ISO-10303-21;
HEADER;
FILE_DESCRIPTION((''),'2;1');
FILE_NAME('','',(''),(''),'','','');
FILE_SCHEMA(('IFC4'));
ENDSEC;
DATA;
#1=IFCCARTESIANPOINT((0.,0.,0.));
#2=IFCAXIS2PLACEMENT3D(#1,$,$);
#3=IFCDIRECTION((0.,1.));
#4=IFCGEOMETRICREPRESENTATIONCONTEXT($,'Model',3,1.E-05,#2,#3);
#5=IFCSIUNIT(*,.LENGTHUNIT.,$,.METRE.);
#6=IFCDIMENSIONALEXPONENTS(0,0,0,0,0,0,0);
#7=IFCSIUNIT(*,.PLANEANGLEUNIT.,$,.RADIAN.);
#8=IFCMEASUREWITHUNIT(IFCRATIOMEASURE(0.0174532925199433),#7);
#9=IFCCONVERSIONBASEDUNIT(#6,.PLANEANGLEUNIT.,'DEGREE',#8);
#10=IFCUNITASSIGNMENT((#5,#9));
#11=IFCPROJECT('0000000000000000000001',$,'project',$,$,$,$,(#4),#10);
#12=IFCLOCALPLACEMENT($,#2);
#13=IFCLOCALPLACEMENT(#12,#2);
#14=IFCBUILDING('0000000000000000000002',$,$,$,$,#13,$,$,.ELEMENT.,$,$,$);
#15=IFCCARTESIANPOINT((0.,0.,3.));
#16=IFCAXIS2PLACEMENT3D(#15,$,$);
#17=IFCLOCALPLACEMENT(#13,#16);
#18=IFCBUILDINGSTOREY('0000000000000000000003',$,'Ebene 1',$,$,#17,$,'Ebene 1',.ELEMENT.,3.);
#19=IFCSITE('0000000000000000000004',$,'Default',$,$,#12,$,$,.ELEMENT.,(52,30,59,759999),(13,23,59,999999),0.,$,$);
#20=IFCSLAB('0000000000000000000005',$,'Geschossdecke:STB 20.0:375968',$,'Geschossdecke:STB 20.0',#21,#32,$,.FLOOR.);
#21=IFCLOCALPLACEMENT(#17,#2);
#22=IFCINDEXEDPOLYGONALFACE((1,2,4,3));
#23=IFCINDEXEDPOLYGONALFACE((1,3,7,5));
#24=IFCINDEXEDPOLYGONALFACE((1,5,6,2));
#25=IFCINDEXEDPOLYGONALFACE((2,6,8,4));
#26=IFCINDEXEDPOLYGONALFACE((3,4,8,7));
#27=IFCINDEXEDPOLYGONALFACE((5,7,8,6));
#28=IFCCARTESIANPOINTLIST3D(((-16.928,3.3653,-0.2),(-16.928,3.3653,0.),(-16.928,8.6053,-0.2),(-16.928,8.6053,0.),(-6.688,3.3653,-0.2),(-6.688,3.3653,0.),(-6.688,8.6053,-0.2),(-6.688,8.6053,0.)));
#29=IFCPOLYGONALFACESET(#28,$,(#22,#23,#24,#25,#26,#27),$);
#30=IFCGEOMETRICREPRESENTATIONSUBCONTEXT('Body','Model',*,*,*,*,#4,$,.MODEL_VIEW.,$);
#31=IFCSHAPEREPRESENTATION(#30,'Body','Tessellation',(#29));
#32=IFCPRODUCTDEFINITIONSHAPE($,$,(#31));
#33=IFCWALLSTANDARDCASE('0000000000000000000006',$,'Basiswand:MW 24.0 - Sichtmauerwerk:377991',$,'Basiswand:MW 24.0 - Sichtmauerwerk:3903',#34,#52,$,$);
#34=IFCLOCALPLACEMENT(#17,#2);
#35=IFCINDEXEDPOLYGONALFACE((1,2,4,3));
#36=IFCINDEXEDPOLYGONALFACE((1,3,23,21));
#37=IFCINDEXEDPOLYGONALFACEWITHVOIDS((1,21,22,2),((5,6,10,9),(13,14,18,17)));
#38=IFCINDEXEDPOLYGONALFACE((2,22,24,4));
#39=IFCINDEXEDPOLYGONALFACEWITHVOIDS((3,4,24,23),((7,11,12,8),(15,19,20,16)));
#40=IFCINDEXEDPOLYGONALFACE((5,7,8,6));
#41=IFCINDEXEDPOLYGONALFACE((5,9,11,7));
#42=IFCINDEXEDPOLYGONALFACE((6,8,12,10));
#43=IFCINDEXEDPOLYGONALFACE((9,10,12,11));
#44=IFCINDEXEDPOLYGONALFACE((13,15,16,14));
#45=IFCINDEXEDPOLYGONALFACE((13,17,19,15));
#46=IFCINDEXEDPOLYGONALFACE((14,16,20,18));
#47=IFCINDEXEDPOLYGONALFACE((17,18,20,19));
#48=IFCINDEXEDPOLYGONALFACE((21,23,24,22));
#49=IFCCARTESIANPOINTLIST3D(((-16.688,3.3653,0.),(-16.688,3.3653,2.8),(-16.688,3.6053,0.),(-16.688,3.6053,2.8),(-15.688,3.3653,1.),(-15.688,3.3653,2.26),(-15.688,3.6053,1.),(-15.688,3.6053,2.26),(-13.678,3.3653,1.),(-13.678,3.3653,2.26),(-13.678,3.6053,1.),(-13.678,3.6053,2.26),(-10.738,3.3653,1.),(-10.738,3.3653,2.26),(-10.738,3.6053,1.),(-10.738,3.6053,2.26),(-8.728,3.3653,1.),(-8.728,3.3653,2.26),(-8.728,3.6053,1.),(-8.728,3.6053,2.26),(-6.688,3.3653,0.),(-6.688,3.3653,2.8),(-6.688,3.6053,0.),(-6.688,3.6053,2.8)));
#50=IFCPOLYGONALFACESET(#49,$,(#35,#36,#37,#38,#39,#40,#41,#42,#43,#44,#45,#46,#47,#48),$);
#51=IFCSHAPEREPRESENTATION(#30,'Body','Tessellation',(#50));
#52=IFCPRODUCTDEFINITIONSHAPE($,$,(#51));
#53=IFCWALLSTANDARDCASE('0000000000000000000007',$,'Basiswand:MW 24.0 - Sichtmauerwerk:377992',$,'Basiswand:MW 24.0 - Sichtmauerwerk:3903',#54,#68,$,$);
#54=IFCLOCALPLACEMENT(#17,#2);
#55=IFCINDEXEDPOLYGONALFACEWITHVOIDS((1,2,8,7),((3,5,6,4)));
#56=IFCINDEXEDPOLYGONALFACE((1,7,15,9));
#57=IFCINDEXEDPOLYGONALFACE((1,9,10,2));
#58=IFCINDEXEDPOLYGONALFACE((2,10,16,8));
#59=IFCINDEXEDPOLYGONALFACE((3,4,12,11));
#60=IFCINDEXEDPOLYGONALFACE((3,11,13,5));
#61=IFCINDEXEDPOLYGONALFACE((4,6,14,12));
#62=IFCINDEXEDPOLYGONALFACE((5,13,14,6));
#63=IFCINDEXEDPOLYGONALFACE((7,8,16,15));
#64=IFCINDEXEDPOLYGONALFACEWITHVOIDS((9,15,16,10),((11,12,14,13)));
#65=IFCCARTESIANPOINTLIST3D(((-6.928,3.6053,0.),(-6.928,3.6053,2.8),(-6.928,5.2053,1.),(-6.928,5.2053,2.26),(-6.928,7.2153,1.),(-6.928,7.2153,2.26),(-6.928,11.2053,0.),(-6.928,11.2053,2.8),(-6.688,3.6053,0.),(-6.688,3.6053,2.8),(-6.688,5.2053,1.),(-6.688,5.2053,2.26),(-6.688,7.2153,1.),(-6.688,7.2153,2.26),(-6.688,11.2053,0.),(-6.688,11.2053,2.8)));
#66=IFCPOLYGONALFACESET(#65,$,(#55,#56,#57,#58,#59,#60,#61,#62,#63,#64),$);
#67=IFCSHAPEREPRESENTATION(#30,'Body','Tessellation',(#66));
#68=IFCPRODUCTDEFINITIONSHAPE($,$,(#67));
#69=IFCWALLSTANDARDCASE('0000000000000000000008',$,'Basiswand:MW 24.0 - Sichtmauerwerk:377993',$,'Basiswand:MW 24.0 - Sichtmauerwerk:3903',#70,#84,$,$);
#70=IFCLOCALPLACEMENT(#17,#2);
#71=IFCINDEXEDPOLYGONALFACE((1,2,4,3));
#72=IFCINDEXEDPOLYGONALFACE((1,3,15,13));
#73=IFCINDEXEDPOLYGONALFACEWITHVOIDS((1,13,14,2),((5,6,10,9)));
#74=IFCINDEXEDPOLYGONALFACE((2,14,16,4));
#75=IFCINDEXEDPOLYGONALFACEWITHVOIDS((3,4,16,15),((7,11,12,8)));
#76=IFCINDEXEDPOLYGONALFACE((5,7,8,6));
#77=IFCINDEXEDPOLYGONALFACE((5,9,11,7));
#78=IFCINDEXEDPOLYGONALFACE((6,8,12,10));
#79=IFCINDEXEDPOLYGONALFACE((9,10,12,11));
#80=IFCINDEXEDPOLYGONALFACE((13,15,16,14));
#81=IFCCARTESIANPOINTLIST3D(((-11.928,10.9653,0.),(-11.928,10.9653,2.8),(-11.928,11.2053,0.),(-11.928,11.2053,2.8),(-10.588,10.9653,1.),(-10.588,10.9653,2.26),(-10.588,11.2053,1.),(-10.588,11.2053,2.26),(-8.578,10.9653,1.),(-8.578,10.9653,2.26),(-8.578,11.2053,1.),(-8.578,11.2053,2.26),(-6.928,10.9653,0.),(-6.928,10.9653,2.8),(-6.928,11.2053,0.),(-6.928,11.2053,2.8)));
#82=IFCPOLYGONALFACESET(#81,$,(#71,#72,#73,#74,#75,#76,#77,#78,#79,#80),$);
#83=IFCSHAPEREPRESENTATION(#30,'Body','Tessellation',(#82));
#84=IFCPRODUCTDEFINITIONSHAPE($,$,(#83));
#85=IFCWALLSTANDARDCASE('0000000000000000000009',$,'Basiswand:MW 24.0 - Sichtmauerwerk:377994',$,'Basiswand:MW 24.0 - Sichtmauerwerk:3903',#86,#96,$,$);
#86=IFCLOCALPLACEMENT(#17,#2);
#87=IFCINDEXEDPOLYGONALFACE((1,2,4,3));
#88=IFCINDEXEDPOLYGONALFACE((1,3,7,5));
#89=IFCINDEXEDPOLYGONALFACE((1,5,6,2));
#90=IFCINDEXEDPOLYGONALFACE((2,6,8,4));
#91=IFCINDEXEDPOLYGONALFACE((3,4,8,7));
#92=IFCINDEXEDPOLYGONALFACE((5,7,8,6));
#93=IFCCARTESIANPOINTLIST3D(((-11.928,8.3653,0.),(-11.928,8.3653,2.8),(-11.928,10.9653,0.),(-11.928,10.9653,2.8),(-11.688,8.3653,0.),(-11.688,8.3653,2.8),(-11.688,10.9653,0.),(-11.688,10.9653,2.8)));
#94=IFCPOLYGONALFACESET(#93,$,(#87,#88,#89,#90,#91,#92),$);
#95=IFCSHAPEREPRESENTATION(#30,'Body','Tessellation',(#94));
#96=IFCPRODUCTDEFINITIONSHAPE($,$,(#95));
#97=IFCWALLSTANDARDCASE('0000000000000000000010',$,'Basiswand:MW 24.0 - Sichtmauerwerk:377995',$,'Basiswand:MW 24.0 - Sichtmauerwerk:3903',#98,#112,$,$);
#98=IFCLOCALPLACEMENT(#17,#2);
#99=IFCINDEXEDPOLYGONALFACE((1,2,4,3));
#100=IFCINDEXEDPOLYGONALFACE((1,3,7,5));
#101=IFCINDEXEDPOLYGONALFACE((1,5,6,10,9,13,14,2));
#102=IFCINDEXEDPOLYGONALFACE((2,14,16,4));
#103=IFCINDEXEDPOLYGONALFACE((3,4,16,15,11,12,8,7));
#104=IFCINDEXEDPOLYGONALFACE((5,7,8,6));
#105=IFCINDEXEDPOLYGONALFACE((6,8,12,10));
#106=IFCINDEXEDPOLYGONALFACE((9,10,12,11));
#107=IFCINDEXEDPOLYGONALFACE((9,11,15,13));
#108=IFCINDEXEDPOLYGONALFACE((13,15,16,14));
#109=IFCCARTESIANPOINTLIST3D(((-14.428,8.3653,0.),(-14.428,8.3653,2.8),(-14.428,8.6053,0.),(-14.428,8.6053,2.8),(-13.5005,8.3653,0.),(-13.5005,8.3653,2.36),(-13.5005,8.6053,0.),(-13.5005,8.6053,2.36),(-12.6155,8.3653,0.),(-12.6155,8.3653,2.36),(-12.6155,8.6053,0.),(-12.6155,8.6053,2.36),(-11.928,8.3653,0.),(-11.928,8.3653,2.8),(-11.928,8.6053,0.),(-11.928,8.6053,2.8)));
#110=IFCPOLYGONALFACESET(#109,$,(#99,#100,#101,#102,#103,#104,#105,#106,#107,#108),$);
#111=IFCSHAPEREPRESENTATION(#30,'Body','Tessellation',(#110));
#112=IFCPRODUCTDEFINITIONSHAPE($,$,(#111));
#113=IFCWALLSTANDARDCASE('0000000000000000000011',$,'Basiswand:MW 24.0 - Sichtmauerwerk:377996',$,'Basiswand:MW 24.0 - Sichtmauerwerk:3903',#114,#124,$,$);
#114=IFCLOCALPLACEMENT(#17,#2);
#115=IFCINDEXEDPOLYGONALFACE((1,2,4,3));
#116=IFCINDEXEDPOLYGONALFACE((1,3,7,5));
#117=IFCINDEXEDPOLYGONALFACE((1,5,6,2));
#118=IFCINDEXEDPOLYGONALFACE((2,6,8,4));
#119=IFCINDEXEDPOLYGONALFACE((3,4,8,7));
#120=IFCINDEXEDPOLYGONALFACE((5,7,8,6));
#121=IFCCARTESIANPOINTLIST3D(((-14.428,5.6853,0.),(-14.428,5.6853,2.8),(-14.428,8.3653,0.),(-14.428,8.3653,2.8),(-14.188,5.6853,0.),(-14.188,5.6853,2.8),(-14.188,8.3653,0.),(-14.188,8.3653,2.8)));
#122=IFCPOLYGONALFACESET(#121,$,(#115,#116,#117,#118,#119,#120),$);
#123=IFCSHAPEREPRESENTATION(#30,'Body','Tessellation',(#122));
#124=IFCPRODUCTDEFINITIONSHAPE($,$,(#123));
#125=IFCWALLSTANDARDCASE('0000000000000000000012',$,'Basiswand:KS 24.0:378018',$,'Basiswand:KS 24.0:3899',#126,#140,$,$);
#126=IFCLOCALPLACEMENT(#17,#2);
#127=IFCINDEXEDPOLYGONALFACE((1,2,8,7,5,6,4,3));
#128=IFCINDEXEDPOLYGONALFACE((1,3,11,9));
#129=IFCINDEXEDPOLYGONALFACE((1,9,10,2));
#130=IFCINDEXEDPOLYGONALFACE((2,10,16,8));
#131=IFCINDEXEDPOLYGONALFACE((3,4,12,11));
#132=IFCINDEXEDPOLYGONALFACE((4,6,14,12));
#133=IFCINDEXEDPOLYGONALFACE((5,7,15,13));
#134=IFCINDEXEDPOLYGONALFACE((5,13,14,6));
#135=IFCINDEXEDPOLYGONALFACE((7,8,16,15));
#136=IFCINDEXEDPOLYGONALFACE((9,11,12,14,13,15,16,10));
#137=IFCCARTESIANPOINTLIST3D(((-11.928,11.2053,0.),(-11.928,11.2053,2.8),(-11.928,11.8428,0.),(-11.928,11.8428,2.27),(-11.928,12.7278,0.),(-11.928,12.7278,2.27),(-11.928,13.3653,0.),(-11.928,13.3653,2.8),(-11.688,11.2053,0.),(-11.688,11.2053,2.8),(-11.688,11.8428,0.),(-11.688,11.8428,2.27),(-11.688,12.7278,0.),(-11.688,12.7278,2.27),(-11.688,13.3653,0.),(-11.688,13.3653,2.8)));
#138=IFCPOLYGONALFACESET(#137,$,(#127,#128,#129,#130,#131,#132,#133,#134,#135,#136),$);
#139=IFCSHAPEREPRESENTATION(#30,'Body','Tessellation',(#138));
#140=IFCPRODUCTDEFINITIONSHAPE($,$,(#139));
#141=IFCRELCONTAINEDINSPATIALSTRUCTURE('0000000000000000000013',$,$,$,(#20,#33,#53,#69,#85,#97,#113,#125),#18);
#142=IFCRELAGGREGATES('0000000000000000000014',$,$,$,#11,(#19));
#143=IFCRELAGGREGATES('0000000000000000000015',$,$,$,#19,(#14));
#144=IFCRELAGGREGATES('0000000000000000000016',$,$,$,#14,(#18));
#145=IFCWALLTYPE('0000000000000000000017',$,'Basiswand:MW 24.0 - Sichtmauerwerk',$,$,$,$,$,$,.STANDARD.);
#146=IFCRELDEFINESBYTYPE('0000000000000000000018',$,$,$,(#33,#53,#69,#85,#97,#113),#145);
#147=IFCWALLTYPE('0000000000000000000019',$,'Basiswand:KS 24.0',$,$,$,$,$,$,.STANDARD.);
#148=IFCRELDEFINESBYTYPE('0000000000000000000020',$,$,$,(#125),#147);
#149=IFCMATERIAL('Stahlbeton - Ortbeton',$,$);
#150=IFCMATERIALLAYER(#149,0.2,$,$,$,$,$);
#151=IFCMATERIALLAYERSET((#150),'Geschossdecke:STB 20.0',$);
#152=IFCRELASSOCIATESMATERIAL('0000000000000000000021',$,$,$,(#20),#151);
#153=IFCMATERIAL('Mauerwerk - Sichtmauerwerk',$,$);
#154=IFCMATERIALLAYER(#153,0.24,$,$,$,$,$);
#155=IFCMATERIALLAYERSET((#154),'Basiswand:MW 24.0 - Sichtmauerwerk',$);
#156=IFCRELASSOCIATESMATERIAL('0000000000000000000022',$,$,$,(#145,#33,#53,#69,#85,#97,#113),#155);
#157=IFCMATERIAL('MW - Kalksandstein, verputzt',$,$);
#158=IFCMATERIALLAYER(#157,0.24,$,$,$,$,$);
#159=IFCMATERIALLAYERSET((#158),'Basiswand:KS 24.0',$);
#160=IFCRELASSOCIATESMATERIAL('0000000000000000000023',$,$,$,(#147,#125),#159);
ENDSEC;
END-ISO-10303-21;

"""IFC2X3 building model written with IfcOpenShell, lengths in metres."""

from ifc_helpers import new_model, entity, si_unit, converted_unit, direction, frame, frame_2d, origin, origin_2d_with_axis, place, context, subcontext, project, spatial, polyline, rectangle, extrude, clip, bounded_halfspace, material, layer, layer_set, layer_usage, type_object, element, save


model = new_model("IFC2X3")

# Units and contexts
model_context = context("Model", 3, precision=1e-05, world=origin(), true_north=direction((0.0, 1.0)))
body_context = subcontext(model_context, "Body", "Model", "MODEL_VIEW")
ifc_project = project(units=[si_unit("LENGTHUNIT", "METRE"), converted_unit("PLANEANGLEUNIT", "DEGREE", entity("IfcRatioMeasure", 0.0174532925199433), si_unit("PLANEANGLEUNIT", "RADIAN"), dimensions=[0, 0, 0, 0, 0, 0, 0])], contexts=[model_context])

# Site, building, storey
site_placement = place(None, origin())
site = spatial("IfcSite", under=ifc_project, at=site_placement, Name="Default", CompositionType="ELEMENT", RefLatitude=(52, 30, 59, 759999), RefLongitude=(13, 23, 59, 999999), RefElevation=0.0)
building_placement = place(site_placement, origin())
building = spatial("IfcBuilding", under=site, at=building_placement, CompositionType="ELEMENT")
storey_placement = place(building_placement, frame((0.0, 0.0, 3.0)))
storey = spatial("IfcBuildingStorey", under=building, at=storey_placement, Name="Ebene 1", LongName="Ebene 1", CompositionType="ELEMENT", Elevation=3.0)

# Shared definitions
ifc_material_1 = material(Name="Stahlbeton - Ortbeton")

# Slab
ifc_layer_1 = layer(ifc_material_1, 0.2)
ifc_layer_set_1 = layer_set([ifc_layer_1], Name="Geschossdecke:STB 20.0")
ifc_layer_usage_1 = layer_usage(ifc_layer_set_1, "AXIS3", "POSITIVE", 0.0)
slab_1_placement = place(storey_placement, origin())
element("IfcSlab", 1, at=slab_1_placement, inside=storey, material=ifc_layer_usage_1, Name="Geschossdecke:STB 20.0:375968", ObjectType="Geschossdecke:STB 20.0", PredefinedType="FLOOR", context=body_context, shape_type="SweptSolid", body=[
    extrude(rectangle(XDim=5.24, YDim=10.24, at=origin_2d_with_axis()), frame((-11.808, 5.9853, 0.0), z_axis=(0.0, 0.0, -1.0), x_axis=(0.0, 1.0, 0.0)), (0.0, 0.0, 1.0), 0.2),
])

# Wall, openings
ifc_material_2 = material(Name="Mauerwerk - Sichtmauerwerk")
ifc_layer_2 = layer(ifc_material_2, 0.24)
ifc_layer_set_2 = layer_set([ifc_layer_2], Name="Basiswand:MW 24.0 - Sichtmauerwerk")
ifc_layer_usage_2 = layer_usage(ifc_layer_set_2, "AXIS2", "NEGATIVE", 0.12)
wall_type_1 = type_object("IfcWallType", Name="Basiswand:MW 24.0 - Sichtmauerwerk", PredefinedType="STANDARD", material=ifc_layer_set_2)
wall_1_placement = place(storey_placement, frame((-16.688, 3.4853, 0.0)))
wall_1 = element("IfcWallStandardCase", 2, at=wall_1_placement, inside=storey, type_object=wall_type_1, material=ifc_layer_usage_2, Name="Basiswand:MW 24.0 - Sichtmauerwerk:377991", ObjectType="Basiswand:MW 24.0 - Sichtmauerwerk:3903", context=body_context, shape_type="Clipping", body=[
    clip(extrude(rectangle(XDim=10.0, YDim=0.24, at=frame_2d((5.0, 0.0), x_axis=(-1.0, 0.0))), origin(), (0.0, 0.0, 1.0), 2.8), bounded_halfspace(frame((0.0, -0.12, 2.8), z_axis=(0.0, 0.0, -1.0), x_axis=(-1.0, 0.0, 0.0)), True, frame((0.0, -0.12, 2.8)), polyline([(0.0, 0.0), (10.0, 0.0), (10.0, 0.24), (9.76, 0.24), (0.0, 0.24), (0.0, 0.0)]))),
])
opening_1_placement = place(wall_1_placement, frame((1.0, -0.12, 1.0)))
element("IfcOpeningElement", 3, at=opening_1_placement, cuts=wall_1, ObjectType="Opening", context=body_context, shape_type="SweptSolid", body=[
    extrude(rectangle(XDim=1.26, YDim=2.01, at=frame_2d((0.63, 1.005), x_axis=(1.0, 0.0))), frame((0.0, 0.0, 0.0), z_axis=(0.0, 1.0, 0.0), x_axis=(0.0, 0.0, 1.0)), (0.0, 0.0, 1.0), 0.24),
])
opening_2_placement = place(wall_1_placement, frame((5.95, -0.12, 1.0)))
element("IfcOpeningElement", 4, at=opening_2_placement, cuts=wall_1, ObjectType="Opening", context=body_context, shape_type="SweptSolid", body=[
    extrude(rectangle(XDim=1.26, YDim=2.01, at=frame_2d((0.63, 1.005), x_axis=(1.0, 0.0))), frame((0.0, 0.0, 0.0), z_axis=(0.0, 1.0, 0.0), x_axis=(0.0, 0.0, 1.0)), (0.0, 0.0, 1.0), 0.24),
])

# Walls, openings
ifc_layer_usage_3 = layer_usage(ifc_layer_set_2, "AXIS2", "NEGATIVE", 0.12)
wall_2_placement = place(storey_placement, frame((-6.808, 3.6053, 0.0), z_axis=(0.0, 0.0, 1.0), x_axis=(0.0, 1.0, 0.0)))
wall_2 = element("IfcWallStandardCase", 5, at=wall_2_placement, inside=storey, type_object=wall_type_1, material=ifc_layer_usage_3, Name="Basiswand:MW 24.0 - Sichtmauerwerk:377992", ObjectType="Basiswand:MW 24.0 - Sichtmauerwerk:3903", context=body_context, shape_type="Clipping", body=[
    clip(clip(extrude(rectangle(XDim=7.6, YDim=0.24, at=frame_2d((3.8, 0.0), x_axis=(-1.0, 0.0))), origin(), (0.0, 0.0, 1.0), 2.8), bounded_halfspace(frame((0.0, -0.12, 2.8), z_axis=(0.0, 0.0, -1.0), x_axis=(0.0, 1.0, 0.0)), True, frame((0.0, -0.12, 2.8)), polyline([(0.0, 0.0), (5.0, 0.0), (5.0, 0.24), (0.0, 0.24), (0.0, 0.0)]))), bounded_halfspace(frame((5.005, -0.12, 2.8), z_axis=(0.0, 0.0, -1.0), x_axis=(1.0, 0.0, 0.0)), True, frame((5.005, -0.12, 2.8)), polyline([(0.0, 0.0), (2.595, 0.0), (2.595, 0.24), (2.355, 0.24), (0.0, 0.24), (0.0, 0.0)]))),
])
opening_3_placement = place(wall_2_placement, frame((1.6, -0.12, 1.0)))
element("IfcOpeningElement", 6, at=opening_3_placement, cuts=wall_2, ObjectType="Opening", context=body_context, shape_type="SweptSolid", body=[
    extrude(rectangle(XDim=1.26, YDim=2.01, at=frame_2d((0.63, 1.005), x_axis=(1.0, 0.0))), frame((0.0, 0.0, 0.0), z_axis=(0.0, 1.0, 0.0), x_axis=(0.0, 0.0, 1.0)), (0.0, 0.0, 1.0), 0.24),
])
ifc_layer_usage_4 = layer_usage(ifc_layer_set_2, "AXIS2", "NEGATIVE", 0.12)
wall_3_placement = place(storey_placement, frame((-6.928, 11.0853, 0.0), z_axis=(0.0, 0.0, 1.0), x_axis=(-1.0, 0.0, 0.0)))
wall_3 = element("IfcWallStandardCase", 7, at=wall_3_placement, inside=storey, type_object=wall_type_1, material=ifc_layer_usage_4, Name="Basiswand:MW 24.0 - Sichtmauerwerk:377993", ObjectType="Basiswand:MW 24.0 - Sichtmauerwerk:3903", context=body_context, shape_type="Clipping", body=[
    clip(extrude(rectangle(XDim=5.0, YDim=0.24, at=frame_2d((2.5, 0.0), x_axis=(-1.0, 0.0))), origin(), (0.0, 0.0, 1.0), 2.8), bounded_halfspace(frame((0.0, -0.12, 2.8), z_axis=(0.0, 0.0, -1.0), x_axis=(0.0, -1.0, 0.0)), True, frame((0.0, -0.12, 2.8)), polyline([(0.0, 0.0), (4.76, 0.0), (5.0, 0.0), (5.0, 0.24), (4.76, 0.24), (0.0, 0.24), (0.0, 0.0)]))),
])
opening_4_placement = place(wall_3_placement, frame((1.65, -0.12, 1.0)))
element("IfcOpeningElement", 8, at=opening_4_placement, cuts=wall_3, ObjectType="Opening", context=body_context, shape_type="SweptSolid", body=[
    extrude(rectangle(XDim=1.26, YDim=2.01, at=frame_2d((0.63, 1.005), x_axis=(1.0, 0.0))), frame((0.0, 0.0, 0.0), z_axis=(0.0, 1.0, 0.0), x_axis=(0.0, 0.0, 1.0)), (0.0, 0.0, 1.0), 0.24),
])

# Wall
ifc_layer_usage_5 = layer_usage(ifc_layer_set_2, "AXIS2", "NEGATIVE", 0.12)
wall_4_placement = place(storey_placement, frame((-11.808, 10.9653, 0.0), z_axis=(0.0, 0.0, 1.0), x_axis=(0.0, -1.0, 0.0)))
element("IfcWallStandardCase", 9, at=wall_4_placement, inside=storey, type_object=wall_type_1, material=ifc_layer_usage_5, Name="Basiswand:MW 24.0 - Sichtmauerwerk:377994", ObjectType="Basiswand:MW 24.0 - Sichtmauerwerk:3903", context=body_context, shape_type="Clipping", body=[
    clip(clip(extrude(rectangle(XDim=2.6, YDim=0.24, at=frame_2d((1.3, 0.0), x_axis=(-1.0, 0.0))), origin(), (0.0, 0.0, 1.0), 2.8), bounded_halfspace(frame((2.36, -0.12, 2.8), z_axis=(0.0, 0.0, -1.0), x_axis=(0.0, -1.0, 0.0)), True, frame((2.36, -0.12, 2.8)), polyline([(0.0, 0.0), (0.24, 0.0), (0.24, 0.24), (0.0, 0.24), (0.0, 0.0)]))), bounded_halfspace(frame((0.0, -0.12, 2.8), z_axis=(0.0, 0.0, -1.0), x_axis=(-1.0, 0.0, 0.0)), True, frame((0.0, -0.12, 2.8)), polyline([(0.0, 0.0), (2.355, 0.0), (2.355, 0.24), (0.0, 0.24), (0.0, 0.0)]))),
])

# Wall, opening
ifc_layer_usage_6 = layer_usage(ifc_layer_set_2, "AXIS2", "NEGATIVE", 0.12)
wall_5_placement = place(storey_placement, frame((-11.928, 8.4853, 0.0), z_axis=(0.0, 0.0, 1.0), x_axis=(-1.0, 0.0, 0.0)))
wall_5 = element("IfcWallStandardCase", 10, at=wall_5_placement, inside=storey, type_object=wall_type_1, material=ifc_layer_usage_6, Name="Basiswand:MW 24.0 - Sichtmauerwerk:377995", ObjectType="Basiswand:MW 24.0 - Sichtmauerwerk:3903", context=body_context, shape_type="Clipping", body=[
    clip(extrude(rectangle(XDim=2.5, YDim=0.24, at=frame_2d((1.25, 0.0), x_axis=(-1.0, 0.0))), origin(), (0.0, 0.0, 1.0), 2.8), bounded_halfspace(frame((0.0, -0.12, 2.8), z_axis=(0.0, 0.0, -1.0), x_axis=(1.0, 0.0, 0.0)), True, frame((0.0, -0.12, 2.8)), polyline([(0.0, 0.0), (2.5, 0.0), (2.5, 0.24), (2.26, 0.24), (0.0, 0.24), (0.0, 0.0)]))),
])
opening_5_placement = place(wall_5_placement, frame((1.5725, 0.12, 0.0)))
element("IfcOpeningElement", 11, at=opening_5_placement, cuts=wall_5, ObjectType="Opening", context=body_context, shape_type="SweptSolid", body=[
    extrude(rectangle(XDim=2.36, YDim=0.885, at=frame_2d((1.18, 0.4425), x_axis=(1.0, 0.0))), frame((0.0, 0.0, 0.0), z_axis=(0.0, -1.0, 0.0), x_axis=(0.0, 0.0, 1.0)), (0.0, 0.0, 1.0), 0.24),
])

# Wall
ifc_layer_usage_7 = layer_usage(ifc_layer_set_2, "AXIS2", "NEGATIVE", 0.12)
wall_6_placement = place(storey_placement, frame((-14.308, 8.3653, 0.0), z_axis=(0.0, 0.0, 1.0), x_axis=(0.0, -1.0, 0.0)))
element("IfcWallStandardCase", 12, at=wall_6_placement, inside=storey, type_object=wall_type_1, material=ifc_layer_usage_7, Name="Basiswand:MW 24.0 - Sichtmauerwerk:377996", ObjectType="Basiswand:MW 24.0 - Sichtmauerwerk:3903", context=body_context, shape_type="Clipping", body=[
    clip(extrude(rectangle(XDim=2.68, YDim=0.24, at=frame_2d((1.34, 0.0), x_axis=(-1.0, 0.0))), origin(), (0.0, 0.0, 1.0), 2.8), bounded_halfspace(frame((0.0, -0.12, 2.8), z_axis=(0.0, 0.0, -1.0), x_axis=(0.0, -1.0, 0.0)), True, frame((0.0, -0.12, 2.8)), polyline([(0.0, 0.0), (2.68, 0.0), (2.68, 0.24), (0.0, 0.24), (0.0, 0.0)]))),
])

# Wall, opening
ifc_material_3 = material(Name="MW - Kalksandstein, verputzt")
ifc_layer_3 = layer(ifc_material_3, 0.24)
ifc_layer_set_3 = layer_set([ifc_layer_3], Name="Basiswand:KS 24.0")
ifc_layer_usage_8 = layer_usage(ifc_layer_set_3, "AXIS2", "NEGATIVE", 0.12)
wall_type_2 = type_object("IfcWallType", Name="Basiswand:KS 24.0", PredefinedType="STANDARD", material=ifc_layer_set_3)
wall_7_placement = place(storey_placement, frame((-11.808, 13.3653, 0.0), z_axis=(0.0, 0.0, 1.0), x_axis=(0.0, -1.0, 0.0)))
wall_7 = element("IfcWallStandardCase", 13, at=wall_7_placement, inside=storey, type_object=wall_type_2, material=ifc_layer_usage_8, Name="Basiswand:KS 24.0:378018", ObjectType="Basiswand:KS 24.0:3899", context=body_context, shape_type="Clipping", body=[
    clip(extrude(rectangle(XDim=2.16, YDim=0.24, at=frame_2d((1.08, 0.0), x_axis=(-1.0, 0.0))), origin(), (0.0, 0.0, 1.0), 2.8), bounded_halfspace(frame((0.0, -0.12, 2.8), z_axis=(0.0, 0.0, -1.0), x_axis=(-1.0, 0.0, 0.0)), True, frame((0.0, -0.12, 2.8)), polyline([(0.0, 0.0), (2.16, 0.0), (2.16, 0.24), (0.0, 0.24), (0.0, 0.0)]))),
])
opening_6_placement = place(wall_7_placement, frame((1.5225, 0.12, 0.0)))
element("IfcOpeningElement", 14, at=opening_6_placement, cuts=wall_7, ObjectType="Opening", context=body_context, shape_type="SweptSolid", body=[
    extrude(rectangle(XDim=2.27, YDim=0.885, at=frame_2d((1.135, 0.4425), x_axis=(1.0, 0.0))), frame((0.0, 0.0, 0.0), z_axis=(0.0, -1.0, 0.0), x_axis=(0.0, 0.0, 1.0)), (0.0, 0.0, 1.0), 0.24),
])

save(model, "model.ifc")
